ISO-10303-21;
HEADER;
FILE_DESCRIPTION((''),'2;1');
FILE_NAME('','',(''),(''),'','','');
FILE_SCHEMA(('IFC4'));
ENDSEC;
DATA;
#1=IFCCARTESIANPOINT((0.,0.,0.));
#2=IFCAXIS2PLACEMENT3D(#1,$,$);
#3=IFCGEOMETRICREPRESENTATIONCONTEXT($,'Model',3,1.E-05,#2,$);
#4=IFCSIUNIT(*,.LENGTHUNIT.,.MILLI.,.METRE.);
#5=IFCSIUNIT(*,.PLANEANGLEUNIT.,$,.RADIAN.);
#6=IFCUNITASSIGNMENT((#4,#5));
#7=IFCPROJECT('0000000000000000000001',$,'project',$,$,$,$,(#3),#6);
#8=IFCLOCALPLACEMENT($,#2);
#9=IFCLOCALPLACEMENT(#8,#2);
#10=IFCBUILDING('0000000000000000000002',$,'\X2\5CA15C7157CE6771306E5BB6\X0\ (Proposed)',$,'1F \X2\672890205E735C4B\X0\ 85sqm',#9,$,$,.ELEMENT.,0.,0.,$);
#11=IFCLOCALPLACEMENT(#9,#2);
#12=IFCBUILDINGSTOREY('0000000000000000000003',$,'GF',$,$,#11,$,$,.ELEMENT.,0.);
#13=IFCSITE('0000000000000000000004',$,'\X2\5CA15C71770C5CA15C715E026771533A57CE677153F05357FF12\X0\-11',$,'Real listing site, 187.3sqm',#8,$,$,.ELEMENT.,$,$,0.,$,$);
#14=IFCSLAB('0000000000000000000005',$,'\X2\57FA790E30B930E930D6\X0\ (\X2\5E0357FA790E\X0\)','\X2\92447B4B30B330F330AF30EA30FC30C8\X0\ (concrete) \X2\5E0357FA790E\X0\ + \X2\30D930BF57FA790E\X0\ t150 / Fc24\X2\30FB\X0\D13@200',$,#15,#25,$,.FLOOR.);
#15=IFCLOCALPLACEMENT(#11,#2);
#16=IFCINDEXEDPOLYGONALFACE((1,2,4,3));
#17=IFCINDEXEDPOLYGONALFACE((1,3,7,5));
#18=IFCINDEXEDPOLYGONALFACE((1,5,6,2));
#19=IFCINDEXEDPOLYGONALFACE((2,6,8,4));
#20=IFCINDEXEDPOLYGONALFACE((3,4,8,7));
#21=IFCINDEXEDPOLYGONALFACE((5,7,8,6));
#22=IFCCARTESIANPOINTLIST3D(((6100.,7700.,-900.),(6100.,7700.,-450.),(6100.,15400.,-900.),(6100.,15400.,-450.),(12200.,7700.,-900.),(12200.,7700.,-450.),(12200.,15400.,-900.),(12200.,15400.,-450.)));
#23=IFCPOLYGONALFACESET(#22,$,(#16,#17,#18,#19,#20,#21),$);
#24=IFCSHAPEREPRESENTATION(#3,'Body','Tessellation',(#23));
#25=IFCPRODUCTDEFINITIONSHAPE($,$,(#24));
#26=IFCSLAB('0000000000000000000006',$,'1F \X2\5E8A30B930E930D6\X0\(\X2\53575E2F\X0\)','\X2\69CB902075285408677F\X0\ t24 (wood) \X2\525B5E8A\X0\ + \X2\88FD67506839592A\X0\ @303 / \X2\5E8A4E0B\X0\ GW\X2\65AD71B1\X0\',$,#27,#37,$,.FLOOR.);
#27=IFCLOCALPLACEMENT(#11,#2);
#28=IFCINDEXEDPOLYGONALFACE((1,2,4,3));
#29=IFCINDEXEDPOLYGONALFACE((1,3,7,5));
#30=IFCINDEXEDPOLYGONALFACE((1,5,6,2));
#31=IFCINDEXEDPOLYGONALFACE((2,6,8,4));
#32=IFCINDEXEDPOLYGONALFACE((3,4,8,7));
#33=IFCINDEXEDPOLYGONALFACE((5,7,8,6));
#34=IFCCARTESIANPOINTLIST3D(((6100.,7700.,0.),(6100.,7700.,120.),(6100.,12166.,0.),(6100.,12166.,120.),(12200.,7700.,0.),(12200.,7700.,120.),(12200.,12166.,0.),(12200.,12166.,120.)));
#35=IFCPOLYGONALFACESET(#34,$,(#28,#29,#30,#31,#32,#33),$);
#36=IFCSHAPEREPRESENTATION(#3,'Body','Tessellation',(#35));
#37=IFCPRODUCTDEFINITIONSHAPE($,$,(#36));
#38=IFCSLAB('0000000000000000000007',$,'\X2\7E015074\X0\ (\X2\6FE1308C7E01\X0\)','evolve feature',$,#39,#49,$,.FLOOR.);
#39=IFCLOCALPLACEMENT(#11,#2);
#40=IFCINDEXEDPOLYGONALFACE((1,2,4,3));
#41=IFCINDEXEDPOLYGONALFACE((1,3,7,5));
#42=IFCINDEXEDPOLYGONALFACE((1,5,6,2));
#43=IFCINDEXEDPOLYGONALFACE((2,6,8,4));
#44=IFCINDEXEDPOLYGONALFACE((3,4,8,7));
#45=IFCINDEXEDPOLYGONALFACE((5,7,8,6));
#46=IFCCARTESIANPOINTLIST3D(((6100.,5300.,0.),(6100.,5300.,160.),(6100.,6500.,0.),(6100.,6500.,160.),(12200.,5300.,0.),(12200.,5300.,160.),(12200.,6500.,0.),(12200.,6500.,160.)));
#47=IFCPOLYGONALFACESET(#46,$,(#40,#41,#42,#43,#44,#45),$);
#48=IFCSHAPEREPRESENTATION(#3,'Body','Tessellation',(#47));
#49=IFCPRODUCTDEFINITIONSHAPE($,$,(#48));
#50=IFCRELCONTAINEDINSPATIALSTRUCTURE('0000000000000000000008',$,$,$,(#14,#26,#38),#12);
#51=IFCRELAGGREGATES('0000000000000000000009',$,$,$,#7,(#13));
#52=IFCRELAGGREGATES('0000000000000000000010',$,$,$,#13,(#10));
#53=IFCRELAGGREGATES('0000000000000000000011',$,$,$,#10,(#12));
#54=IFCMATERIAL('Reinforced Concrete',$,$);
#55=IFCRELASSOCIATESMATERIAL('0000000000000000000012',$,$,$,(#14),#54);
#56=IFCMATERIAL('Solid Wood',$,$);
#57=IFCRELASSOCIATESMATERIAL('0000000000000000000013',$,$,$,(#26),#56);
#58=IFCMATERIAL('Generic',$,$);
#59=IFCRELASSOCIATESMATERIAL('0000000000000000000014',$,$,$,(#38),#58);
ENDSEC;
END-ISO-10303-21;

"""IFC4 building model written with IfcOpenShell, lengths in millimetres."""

from ifc_helpers import new_model, si_unit, frame, frame_2d, origin, place, context, project, spatial, rectangle, extrude, material, element, save


model = new_model("IFC4")

# Units and contexts
model_context = context("Model", 3, precision=1e-05, world=origin())
ifc_project = project(units=[si_unit("LENGTHUNIT", "METRE", prefix="MILLI"), si_unit("PLANEANGLEUNIT", "RADIAN")], contexts=[model_context])

# Site, building, storey
site_placement = place(None, origin())
site = spatial("IfcSite", under=ifc_project, at=site_placement, Name="岡山県岡山市東区城東台南２-11", ObjectType="Real listing site, 187.3sqm", CompositionType="ELEMENT", RefElevation=0.0)
building_placement = place(site_placement, origin())
building = spatial("IfcBuilding", under=site, at=building_placement, Name="岡山城東の家 (Proposed)", ObjectType="1F 木造平屋 85sqm", CompositionType="ELEMENT", ElevationOfRefHeight=0.0, ElevationOfTerrain=0.0)
storey_placement = place(building_placement, origin())
storey = spatial("IfcBuildingStorey", under=building, at=storey_placement, Name="GF", CompositionType="ELEMENT", Elevation=0.0)

# Slabs
ifc_material_1 = material(Name="Reinforced Concrete")
slab_1_placement = place(storey_placement, frame((3050.0, 3850.0, -450.0)))
element("IfcSlab", 1, at=slab_1_placement, inside=storey, material=ifc_material_1, Name="基礎スラブ (布基礎)", Description="鉄筋コンクリート (concrete) 布基礎 + ベタ基礎 t150 / Fc24・D13@200", PredefinedType="FLOOR", context=model_context, shape_type="SweptSolid", body=[
    extrude(rectangle(XDim=6100.0, YDim=7700.0, at=frame_2d((3050.0, 3850.0))), frame((3050.0, 3850.0, -450.0)), (0.0, 0.0, 1.0), 450.0),
])
ifc_material_2 = material(Name="Solid Wood")
slab_2_placement = place(storey_placement, frame((3050.0, 3850.0, 0.0)))
element("IfcSlab", 2, at=slab_2_placement, inside=storey, material=ifc_material_2, Name="1F 床スラブ(南帯)", Description="構造用合板 t24 (wood) 剛床 + 製材根太 @303 / 床下 GW断熱", PredefinedType="FLOOR", context=model_context, shape_type="SweptSolid", body=[
    extrude(rectangle(XDim=6100.0, YDim=4466.0, at=frame_2d((3050.0, 2233.0))), frame((3050.0, 3850.0, 0.0)), (0.0, 0.0, 1.0), 120.0),
])
ifc_material_3 = material(Name="Generic")
slab_3_placement = place(storey_placement, frame((3050.0, 2650.0, 0.0)))
element("IfcSlab", 3, at=slab_3_placement, inside=storey, material=ifc_material_3, Name="縁側 (濡れ縁)", Description="evolve feature", PredefinedType="FLOOR", context=model_context, shape_type="SweptSolid", body=[
    extrude(rectangle(XDim=6100.0, YDim=1200.0, at=frame_2d((3050.0, 600.0))), frame((3050.0, 2650.0, 0.0)), (0.0, 0.0, 1.0), 160.0),
])

save(model, "model.ifc")
